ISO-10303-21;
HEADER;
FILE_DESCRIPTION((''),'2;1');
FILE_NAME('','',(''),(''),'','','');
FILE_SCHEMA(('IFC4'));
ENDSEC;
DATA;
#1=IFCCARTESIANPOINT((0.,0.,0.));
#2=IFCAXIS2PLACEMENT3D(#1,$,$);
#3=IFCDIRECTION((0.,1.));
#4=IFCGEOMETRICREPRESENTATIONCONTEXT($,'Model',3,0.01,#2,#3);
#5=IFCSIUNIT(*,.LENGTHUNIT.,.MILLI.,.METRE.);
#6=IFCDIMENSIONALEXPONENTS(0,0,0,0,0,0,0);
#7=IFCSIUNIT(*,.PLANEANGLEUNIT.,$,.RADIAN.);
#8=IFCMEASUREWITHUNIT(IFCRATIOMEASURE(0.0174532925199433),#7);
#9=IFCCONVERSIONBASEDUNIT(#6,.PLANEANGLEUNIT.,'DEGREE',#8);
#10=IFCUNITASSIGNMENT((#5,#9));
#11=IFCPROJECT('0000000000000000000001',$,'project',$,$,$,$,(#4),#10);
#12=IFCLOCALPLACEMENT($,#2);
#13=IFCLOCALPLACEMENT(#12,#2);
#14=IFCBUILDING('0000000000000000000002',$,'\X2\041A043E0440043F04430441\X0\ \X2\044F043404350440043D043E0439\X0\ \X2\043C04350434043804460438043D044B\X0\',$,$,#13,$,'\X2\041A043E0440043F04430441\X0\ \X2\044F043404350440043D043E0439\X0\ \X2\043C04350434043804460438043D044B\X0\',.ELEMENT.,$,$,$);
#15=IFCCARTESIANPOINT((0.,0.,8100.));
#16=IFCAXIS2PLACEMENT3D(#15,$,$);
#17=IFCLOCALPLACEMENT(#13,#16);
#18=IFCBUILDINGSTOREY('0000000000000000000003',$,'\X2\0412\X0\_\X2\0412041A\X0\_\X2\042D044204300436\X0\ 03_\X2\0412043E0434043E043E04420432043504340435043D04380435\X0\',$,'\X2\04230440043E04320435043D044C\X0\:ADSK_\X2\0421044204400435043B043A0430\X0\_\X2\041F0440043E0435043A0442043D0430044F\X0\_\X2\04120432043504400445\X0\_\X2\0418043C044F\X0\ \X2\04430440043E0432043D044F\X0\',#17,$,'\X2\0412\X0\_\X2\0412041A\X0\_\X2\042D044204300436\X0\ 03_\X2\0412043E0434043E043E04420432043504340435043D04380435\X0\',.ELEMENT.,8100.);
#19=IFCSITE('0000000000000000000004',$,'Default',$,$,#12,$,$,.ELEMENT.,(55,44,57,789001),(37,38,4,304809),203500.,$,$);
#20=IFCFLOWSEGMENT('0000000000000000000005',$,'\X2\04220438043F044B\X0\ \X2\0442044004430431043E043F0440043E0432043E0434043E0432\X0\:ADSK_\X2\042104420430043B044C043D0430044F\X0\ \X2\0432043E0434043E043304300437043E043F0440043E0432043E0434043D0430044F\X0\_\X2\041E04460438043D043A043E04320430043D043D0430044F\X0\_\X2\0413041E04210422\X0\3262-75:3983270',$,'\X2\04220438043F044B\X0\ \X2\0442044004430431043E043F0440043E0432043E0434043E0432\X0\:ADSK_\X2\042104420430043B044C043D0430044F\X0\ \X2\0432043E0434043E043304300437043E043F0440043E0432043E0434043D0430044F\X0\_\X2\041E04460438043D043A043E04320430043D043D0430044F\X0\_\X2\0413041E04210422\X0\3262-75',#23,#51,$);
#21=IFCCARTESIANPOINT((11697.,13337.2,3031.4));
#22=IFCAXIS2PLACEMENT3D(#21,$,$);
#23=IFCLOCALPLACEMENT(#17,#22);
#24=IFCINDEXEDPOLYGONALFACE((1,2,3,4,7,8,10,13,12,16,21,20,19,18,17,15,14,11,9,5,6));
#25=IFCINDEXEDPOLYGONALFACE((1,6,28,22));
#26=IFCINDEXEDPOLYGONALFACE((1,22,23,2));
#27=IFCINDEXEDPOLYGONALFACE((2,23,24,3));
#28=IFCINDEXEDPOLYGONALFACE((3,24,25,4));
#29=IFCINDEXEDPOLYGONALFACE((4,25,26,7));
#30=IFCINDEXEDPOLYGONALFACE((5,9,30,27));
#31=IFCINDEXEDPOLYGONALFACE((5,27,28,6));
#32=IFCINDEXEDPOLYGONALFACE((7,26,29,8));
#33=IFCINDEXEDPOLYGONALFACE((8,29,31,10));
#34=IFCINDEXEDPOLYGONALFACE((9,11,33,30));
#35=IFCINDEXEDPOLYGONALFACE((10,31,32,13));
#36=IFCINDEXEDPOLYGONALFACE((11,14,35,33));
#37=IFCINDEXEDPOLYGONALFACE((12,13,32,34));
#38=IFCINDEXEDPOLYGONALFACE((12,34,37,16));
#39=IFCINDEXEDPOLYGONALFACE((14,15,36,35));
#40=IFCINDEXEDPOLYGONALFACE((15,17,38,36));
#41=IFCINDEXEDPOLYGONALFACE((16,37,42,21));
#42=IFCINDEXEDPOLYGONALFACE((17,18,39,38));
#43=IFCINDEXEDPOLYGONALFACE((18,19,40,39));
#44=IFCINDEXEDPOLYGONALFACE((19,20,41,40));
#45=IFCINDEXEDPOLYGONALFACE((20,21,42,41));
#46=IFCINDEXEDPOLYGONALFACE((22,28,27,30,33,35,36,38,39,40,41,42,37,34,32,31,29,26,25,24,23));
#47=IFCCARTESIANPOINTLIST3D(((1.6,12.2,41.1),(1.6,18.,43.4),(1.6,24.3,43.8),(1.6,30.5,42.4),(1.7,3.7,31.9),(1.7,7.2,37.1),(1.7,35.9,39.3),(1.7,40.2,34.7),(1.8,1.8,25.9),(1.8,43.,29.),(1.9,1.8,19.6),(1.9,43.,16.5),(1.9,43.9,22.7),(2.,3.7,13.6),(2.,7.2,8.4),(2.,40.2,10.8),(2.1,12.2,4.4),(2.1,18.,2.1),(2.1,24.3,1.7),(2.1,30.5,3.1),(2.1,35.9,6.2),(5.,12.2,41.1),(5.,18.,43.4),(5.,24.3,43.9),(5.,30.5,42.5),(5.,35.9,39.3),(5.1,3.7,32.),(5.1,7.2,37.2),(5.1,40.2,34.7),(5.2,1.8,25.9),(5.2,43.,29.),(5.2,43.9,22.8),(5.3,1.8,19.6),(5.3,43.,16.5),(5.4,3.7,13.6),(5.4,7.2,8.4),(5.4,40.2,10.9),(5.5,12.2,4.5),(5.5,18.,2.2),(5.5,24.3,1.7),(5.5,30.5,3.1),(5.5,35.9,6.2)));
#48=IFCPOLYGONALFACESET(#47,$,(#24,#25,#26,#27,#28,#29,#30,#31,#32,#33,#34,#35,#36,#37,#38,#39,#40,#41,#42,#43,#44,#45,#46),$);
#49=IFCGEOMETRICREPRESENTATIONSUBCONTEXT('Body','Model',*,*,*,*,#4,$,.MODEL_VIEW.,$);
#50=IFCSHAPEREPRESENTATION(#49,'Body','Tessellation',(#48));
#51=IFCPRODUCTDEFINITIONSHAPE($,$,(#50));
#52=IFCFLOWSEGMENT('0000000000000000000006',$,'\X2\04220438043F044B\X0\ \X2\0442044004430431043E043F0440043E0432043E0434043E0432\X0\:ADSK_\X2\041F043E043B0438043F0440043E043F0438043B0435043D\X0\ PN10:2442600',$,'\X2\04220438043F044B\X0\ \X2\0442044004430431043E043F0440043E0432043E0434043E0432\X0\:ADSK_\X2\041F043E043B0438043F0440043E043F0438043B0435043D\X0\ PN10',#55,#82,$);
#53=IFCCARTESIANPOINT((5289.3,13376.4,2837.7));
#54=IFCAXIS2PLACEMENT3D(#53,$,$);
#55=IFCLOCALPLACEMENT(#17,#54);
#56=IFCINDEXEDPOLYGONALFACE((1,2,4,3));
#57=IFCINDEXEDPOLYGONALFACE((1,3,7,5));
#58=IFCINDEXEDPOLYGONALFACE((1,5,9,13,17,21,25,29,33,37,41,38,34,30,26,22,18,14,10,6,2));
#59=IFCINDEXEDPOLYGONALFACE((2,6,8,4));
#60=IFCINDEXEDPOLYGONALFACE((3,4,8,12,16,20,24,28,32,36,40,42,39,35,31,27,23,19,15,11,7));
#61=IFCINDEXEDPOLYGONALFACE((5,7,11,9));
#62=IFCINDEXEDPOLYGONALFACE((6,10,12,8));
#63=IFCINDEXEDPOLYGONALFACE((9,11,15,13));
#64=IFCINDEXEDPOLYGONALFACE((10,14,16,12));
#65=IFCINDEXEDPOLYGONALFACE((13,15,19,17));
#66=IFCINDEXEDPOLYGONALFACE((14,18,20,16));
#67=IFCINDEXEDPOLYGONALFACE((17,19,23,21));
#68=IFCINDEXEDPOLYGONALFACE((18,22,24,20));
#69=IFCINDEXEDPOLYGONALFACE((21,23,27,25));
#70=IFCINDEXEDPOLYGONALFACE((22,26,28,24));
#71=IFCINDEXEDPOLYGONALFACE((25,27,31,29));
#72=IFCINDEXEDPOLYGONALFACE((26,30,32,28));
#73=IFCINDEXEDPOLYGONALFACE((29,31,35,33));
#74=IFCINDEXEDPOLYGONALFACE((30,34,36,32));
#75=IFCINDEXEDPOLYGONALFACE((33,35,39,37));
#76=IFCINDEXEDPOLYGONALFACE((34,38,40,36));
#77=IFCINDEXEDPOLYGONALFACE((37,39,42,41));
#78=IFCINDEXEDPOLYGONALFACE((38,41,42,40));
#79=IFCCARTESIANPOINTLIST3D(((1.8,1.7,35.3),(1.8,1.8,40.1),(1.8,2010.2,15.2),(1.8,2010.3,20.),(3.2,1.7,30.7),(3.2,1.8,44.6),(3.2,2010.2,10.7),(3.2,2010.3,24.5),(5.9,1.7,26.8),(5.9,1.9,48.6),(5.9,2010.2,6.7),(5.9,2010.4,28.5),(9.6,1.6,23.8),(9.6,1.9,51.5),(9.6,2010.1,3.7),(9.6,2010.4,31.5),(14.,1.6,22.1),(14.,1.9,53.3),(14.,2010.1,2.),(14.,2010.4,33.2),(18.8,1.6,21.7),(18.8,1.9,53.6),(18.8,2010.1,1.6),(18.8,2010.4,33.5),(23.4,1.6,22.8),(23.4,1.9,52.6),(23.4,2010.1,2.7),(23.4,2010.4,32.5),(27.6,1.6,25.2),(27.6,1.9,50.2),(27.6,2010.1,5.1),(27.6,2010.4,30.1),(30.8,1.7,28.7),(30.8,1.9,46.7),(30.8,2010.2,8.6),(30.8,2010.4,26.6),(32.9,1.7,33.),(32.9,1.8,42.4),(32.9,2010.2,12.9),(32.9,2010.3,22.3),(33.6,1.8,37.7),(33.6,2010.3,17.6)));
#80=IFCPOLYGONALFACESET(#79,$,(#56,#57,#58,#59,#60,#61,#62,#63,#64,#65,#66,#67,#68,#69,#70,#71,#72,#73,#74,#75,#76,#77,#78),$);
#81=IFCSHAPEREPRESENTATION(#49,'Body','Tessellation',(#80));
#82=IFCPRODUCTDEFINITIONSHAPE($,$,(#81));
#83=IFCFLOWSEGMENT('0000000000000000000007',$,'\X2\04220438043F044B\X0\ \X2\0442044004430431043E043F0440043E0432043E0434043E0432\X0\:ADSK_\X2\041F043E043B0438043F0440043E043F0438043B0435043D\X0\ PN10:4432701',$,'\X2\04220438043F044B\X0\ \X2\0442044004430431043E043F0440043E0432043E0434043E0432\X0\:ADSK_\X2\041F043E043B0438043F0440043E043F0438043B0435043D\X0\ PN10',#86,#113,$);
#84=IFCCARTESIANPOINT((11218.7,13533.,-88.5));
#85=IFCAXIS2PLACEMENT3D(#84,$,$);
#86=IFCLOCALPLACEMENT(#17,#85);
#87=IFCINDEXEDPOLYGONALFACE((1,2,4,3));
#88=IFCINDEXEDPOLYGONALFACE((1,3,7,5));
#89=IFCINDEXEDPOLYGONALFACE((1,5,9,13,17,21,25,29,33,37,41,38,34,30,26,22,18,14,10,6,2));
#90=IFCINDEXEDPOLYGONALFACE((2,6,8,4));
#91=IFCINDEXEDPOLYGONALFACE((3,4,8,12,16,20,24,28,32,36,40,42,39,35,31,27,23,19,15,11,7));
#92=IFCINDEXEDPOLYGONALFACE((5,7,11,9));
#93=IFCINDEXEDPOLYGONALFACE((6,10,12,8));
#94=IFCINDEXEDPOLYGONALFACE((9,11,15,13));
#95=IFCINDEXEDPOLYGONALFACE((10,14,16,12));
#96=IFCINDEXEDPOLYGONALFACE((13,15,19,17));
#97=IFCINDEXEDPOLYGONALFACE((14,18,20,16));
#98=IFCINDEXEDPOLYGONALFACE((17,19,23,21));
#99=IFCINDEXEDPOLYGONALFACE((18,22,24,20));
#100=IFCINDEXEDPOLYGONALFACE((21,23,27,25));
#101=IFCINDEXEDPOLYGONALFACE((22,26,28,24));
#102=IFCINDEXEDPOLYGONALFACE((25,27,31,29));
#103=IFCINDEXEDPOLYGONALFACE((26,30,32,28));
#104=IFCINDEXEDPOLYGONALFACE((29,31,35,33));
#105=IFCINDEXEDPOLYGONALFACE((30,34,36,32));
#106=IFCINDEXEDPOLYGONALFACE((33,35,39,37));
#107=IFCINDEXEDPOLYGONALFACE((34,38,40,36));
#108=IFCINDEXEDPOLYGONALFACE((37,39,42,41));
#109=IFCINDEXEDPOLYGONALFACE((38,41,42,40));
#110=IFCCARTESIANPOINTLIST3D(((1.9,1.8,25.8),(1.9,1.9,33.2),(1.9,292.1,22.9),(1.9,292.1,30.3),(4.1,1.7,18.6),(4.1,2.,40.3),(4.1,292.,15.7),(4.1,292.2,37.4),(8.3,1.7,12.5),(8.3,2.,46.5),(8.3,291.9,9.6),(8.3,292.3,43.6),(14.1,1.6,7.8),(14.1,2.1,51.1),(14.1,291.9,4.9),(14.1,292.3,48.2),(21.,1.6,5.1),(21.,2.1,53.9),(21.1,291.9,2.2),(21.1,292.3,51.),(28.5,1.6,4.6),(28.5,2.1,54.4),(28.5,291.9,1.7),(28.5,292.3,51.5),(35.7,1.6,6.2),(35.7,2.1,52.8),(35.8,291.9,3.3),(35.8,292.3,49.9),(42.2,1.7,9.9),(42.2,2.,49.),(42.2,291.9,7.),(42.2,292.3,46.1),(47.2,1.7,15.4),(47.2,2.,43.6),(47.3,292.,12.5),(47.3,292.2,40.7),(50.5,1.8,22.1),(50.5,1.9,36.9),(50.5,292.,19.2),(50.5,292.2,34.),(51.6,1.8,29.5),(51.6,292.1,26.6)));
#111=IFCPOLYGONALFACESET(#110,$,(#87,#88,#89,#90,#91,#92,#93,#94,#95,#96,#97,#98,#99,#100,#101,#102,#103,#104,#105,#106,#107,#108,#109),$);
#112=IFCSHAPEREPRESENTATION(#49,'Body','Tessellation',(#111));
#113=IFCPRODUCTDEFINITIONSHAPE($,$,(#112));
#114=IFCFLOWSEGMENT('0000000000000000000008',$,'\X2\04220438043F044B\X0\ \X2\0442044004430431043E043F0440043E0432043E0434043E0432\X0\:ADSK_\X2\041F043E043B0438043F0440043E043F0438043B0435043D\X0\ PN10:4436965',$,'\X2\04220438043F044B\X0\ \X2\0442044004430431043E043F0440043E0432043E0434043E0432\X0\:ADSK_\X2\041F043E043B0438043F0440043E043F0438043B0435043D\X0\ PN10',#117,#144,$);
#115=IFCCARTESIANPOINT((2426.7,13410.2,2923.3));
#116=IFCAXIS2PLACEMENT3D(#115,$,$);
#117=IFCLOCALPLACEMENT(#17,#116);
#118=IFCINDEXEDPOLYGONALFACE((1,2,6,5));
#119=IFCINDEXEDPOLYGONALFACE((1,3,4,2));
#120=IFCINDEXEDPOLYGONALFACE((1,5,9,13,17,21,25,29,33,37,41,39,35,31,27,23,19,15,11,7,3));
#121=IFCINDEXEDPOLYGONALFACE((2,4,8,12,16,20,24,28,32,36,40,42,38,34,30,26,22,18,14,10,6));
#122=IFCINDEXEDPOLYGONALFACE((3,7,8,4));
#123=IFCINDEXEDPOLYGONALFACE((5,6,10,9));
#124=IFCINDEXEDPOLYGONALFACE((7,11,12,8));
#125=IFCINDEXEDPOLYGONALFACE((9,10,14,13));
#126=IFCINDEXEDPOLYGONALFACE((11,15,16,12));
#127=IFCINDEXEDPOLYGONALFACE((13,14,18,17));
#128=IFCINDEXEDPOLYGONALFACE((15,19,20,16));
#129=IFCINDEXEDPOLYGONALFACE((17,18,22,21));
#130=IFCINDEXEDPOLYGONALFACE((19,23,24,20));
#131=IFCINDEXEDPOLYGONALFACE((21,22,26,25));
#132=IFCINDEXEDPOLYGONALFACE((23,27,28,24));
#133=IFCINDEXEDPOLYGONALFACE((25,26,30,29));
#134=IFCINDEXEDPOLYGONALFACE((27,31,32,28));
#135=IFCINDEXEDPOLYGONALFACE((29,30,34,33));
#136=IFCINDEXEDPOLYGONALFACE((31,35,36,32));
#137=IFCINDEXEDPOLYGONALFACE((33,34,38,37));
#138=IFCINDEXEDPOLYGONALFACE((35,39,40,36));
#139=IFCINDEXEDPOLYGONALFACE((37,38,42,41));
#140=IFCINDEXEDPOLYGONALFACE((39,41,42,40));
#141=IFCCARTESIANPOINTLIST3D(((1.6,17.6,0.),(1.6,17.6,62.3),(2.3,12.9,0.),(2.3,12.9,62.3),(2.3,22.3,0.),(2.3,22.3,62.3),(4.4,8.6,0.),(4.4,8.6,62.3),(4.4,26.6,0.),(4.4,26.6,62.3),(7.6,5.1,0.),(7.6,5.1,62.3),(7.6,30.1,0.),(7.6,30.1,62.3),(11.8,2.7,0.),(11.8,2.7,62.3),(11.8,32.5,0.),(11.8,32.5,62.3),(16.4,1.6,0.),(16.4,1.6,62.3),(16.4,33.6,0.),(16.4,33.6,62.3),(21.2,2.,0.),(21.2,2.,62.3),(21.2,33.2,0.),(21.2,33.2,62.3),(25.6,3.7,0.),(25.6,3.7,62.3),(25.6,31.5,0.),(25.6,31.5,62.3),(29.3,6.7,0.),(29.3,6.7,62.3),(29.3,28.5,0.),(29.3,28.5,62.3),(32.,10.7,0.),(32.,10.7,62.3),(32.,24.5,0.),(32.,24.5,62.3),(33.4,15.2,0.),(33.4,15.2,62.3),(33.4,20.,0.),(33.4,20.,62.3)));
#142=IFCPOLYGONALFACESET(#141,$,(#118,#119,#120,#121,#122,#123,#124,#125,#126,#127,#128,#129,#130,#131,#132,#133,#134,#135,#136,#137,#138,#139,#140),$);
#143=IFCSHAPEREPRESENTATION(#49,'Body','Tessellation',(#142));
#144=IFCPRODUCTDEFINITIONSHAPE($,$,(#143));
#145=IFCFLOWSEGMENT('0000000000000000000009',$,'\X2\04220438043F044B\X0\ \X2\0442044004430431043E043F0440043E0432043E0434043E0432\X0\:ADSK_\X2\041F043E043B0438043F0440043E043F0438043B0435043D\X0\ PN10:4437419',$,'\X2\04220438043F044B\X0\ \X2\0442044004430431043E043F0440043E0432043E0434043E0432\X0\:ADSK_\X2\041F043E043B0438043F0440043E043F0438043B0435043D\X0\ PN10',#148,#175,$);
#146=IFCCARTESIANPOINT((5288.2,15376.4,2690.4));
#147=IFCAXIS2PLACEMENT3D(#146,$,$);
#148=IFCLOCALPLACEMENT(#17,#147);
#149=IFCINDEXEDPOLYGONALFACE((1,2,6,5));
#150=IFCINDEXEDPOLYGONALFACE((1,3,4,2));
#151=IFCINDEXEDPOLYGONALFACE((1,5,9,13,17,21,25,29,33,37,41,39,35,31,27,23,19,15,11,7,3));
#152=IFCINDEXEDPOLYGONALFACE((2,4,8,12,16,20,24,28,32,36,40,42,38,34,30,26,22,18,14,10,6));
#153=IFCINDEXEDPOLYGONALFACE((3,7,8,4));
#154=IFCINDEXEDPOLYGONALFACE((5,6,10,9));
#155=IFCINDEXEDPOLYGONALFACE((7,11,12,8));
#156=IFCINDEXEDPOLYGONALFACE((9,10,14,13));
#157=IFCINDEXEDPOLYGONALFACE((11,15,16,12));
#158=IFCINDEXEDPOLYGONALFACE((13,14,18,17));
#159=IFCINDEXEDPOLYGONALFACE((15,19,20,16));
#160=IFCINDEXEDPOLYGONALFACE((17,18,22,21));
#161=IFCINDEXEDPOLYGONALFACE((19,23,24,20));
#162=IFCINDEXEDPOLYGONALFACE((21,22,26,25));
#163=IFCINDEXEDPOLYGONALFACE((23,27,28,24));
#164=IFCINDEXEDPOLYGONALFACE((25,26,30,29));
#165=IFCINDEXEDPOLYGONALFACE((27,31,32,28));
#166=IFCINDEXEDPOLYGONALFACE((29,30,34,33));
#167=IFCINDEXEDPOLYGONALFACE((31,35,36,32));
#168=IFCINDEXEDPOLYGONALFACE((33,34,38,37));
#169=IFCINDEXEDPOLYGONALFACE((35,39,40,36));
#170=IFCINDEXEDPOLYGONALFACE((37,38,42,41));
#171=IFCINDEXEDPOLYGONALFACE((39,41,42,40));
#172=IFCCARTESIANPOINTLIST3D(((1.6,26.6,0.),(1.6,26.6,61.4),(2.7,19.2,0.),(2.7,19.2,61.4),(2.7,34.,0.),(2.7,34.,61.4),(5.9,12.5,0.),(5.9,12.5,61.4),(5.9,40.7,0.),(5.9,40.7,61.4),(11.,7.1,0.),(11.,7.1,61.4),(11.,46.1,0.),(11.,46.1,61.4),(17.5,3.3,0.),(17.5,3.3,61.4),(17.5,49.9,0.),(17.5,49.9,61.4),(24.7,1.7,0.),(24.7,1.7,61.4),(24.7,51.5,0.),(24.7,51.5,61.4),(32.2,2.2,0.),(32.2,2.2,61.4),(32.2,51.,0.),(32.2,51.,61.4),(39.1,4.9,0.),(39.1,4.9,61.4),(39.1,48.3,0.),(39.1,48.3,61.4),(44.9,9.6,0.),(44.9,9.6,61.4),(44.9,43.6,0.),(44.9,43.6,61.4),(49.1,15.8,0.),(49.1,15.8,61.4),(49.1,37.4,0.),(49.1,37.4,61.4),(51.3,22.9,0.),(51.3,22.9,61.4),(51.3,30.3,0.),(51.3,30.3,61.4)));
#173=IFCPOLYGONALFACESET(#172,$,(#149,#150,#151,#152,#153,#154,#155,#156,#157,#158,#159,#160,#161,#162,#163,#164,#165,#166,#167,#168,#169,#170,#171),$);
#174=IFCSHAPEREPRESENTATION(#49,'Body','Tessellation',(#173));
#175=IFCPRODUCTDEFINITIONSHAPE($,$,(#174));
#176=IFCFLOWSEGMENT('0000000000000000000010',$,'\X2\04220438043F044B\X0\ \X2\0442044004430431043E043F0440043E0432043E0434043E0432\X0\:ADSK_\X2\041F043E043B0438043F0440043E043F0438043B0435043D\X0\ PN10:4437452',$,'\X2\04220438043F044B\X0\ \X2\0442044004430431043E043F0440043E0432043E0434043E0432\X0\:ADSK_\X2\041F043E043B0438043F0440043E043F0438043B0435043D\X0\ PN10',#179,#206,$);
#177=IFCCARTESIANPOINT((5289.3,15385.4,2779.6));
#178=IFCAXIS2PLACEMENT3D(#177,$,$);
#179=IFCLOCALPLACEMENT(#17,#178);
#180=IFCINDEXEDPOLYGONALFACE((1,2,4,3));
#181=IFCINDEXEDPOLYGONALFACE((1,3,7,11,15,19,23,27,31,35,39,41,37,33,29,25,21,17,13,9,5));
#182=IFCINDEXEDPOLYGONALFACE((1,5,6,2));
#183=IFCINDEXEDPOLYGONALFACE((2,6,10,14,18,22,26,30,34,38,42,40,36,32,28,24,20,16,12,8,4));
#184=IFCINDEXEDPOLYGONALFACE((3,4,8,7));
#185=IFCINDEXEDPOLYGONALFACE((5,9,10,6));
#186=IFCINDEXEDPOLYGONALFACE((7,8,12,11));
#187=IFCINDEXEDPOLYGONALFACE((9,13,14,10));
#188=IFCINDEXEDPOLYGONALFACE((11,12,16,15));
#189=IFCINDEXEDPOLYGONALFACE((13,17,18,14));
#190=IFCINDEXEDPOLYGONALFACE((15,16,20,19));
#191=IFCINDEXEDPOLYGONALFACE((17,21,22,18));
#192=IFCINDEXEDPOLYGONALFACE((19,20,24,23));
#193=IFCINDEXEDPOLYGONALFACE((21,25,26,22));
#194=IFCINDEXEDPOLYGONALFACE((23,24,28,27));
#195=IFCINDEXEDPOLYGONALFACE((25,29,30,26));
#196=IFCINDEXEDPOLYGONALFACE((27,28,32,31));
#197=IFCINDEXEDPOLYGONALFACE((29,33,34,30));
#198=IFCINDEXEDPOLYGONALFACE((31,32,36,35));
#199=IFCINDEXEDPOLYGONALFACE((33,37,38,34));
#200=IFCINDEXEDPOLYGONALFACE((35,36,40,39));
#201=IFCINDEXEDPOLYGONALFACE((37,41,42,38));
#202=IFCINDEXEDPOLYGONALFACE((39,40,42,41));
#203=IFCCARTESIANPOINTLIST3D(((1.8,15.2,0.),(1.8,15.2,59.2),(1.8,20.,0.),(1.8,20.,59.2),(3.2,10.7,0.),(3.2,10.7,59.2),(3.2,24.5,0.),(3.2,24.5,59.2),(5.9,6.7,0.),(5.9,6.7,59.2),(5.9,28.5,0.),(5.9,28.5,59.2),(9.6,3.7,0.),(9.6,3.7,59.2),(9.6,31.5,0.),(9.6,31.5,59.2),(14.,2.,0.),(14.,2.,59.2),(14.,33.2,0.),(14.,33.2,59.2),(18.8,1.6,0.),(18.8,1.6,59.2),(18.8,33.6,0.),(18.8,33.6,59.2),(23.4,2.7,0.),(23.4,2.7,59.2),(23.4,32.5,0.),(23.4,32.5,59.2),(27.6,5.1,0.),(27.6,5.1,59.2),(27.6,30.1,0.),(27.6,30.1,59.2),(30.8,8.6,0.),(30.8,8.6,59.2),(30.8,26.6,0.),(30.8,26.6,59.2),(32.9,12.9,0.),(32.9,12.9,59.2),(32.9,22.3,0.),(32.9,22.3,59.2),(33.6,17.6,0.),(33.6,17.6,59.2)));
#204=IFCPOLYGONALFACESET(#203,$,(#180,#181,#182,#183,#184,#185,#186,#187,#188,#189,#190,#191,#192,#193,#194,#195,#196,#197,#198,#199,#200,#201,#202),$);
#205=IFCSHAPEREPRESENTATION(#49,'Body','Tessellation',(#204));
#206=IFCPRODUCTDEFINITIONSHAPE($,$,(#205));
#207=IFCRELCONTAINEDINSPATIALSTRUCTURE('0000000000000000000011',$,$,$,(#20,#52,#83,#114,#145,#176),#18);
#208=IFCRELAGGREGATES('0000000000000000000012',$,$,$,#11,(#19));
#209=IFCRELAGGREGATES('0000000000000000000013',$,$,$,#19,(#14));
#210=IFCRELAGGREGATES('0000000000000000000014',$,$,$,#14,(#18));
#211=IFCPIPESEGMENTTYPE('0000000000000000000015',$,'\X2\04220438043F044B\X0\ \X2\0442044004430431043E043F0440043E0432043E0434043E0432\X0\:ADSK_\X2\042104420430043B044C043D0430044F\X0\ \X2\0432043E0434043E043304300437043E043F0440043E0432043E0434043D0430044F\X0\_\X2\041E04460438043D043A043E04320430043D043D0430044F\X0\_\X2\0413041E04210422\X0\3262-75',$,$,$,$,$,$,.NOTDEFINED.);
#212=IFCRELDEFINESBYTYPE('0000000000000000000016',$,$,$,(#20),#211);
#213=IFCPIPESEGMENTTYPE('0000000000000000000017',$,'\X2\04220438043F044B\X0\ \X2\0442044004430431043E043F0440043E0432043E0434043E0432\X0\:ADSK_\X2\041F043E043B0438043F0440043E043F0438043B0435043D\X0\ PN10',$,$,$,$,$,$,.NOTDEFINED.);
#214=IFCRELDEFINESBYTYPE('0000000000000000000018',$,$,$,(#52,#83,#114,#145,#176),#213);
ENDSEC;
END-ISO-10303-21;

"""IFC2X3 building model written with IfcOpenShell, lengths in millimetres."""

from ifc_helpers import new_model, entity, si_unit, converted_unit, direction, frame, origin, origin_2d_with_axis, place, context, subcontext, project, spatial, circle, extrude, type_object, element, save


model = new_model("IFC2X3")

# Units and contexts
model_context = context("Model", 3, precision=0.01, world=origin(), true_north=direction((0.0, 1.0)))
body_context = subcontext(model_context, "Body", "Model", "MODEL_VIEW")
ifc_project = project(units=[si_unit("LENGTHUNIT", "METRE", prefix="MILLI"), converted_unit("PLANEANGLEUNIT", "DEGREE", entity("IfcRatioMeasure", 0.0174532925199433), si_unit("PLANEANGLEUNIT", "RADIAN"), dimensions=[0, 0, 0, 0, 0, 0, 0])], contexts=[model_context])

# Site, building, storey
site_placement = place(None, origin())
site = spatial("IfcSite", under=ifc_project, at=site_placement, Name="Default", CompositionType="ELEMENT", RefLatitude=(55, 44, 57, 789001), RefLongitude=(37, 38, 4, 304809), RefElevation=203500.0)
building_placement = place(site_placement, origin())
building = spatial("IfcBuilding", under=site, at=building_placement, Name="Корпус ядерной медицины", LongName="Корпус ядерной медицины", CompositionType="ELEMENT")
storey_placement = place(building_placement, frame((0.0, 0.0, 8100.0)))
storey = spatial("IfcBuildingStorey", under=building, at=storey_placement, Name="В_ВК_Этаж 03_Водоотведение", ObjectType="Уровень:ADSK_Стрелка_Проектная_Вверх_Имя уровня", LongName="В_ВК_Этаж 03_Водоотведение", CompositionType="ELEMENT", Elevation=8100.0)

# Flow segments
pipe_segment_type_1 = type_object("IfcPipeSegmentType", Name="Типы трубопроводов:ADSK_Стальная водогазопроводная_Оцинкованная_ГОСТ3262-75", PredefinedType="NOTDEFINED")
flow_segment_1_placement = place(storey_placement, frame((11697.0, 13337.2, 3031.4)))
element("IfcFlowSegment", 1, at=flow_segment_1_placement, inside=storey, type_object=pipe_segment_type_1, Name="Типы трубопроводов:ADSK_Стальная водогазопроводная_Оцинкованная_ГОСТ3262-75:3983270", ObjectType="Типы трубопроводов:ADSK_Стальная водогазопроводная_Оцинкованная_ГОСТ3262-75", context=body_context, shape_type="SweptSolid", body=[
    extrude(circle(Radius=21.1, at=origin_2d_with_axis()), frame((1.9, 22.8, 22.7), z_axis=(0.999923, 0.0, 0.012377), x_axis=(0.0, 1.0, 0.0)), (0.0, 0.0, 1.0), 3.4),
])
pipe_segment_type_2 = type_object("IfcPipeSegmentType", Name="Типы трубопроводов:ADSK_Полипропилен PN10", PredefinedType="NOTDEFINED")
flow_segment_2_placement = place(storey_placement, frame((5289.3, 13376.4, 2837.7)))
element("IfcFlowSegment", 2, at=flow_segment_2_placement, inside=storey, type_object=pipe_segment_type_2, Name="Типы трубопроводов:ADSK_Полипропилен PN10:2442600", ObjectType="Типы трубопроводов:ADSK_Полипропилен PN10", context=body_context, shape_type="SweptSolid", body=[
    extrude(circle(Radius=16.0, at=origin_2d_with_axis()), frame((17.6, 1.8, 37.7), z_axis=(0.0, 0.99995, -0.01), x_axis=(1.0, 0.0, 0.0)), (0.0, 0.0, 1.0), 2008.6),
])
flow_segment_3_placement = place(storey_placement, frame((11218.7, 13533.0, -88.5)))
element("IfcFlowSegment", 3, at=flow_segment_3_placement, inside=storey, type_object=pipe_segment_type_2, Name="Типы трубопроводов:ADSK_Полипропилен PN10:4432701", ObjectType="Типы трубопроводов:ADSK_Полипропилен PN10", context=body_context, shape_type="SweptSolid", body=[
    extrude(circle(Radius=25.0, at=origin_2d_with_axis()), frame((26.6, 292.1, 26.6), z_axis=(-0.000095, -0.99995, 0.009999), x_axis=(1.0, -0.000095, 0.0)), (0.0, 0.0, 1.0), 290.3),
])
flow_segment_4_placement = place(storey_placement, frame((2426.7, 13410.2, 2923.3)))
element("IfcFlowSegment", 4, at=flow_segment_4_placement, inside=storey, type_object=pipe_segment_type_2, Name="Типы трубопроводов:ADSK_Полипропилен PN10:4436965", ObjectType="Типы трубопроводов:ADSK_Полипропилен PN10", context=body_context, shape_type="SweptSolid", body=[
    extrude(circle(Radius=16.0, at=origin_2d_with_axis()), frame((17.6, 17.6, 0.0), z_axis=(0.0, 0.0, 1.0), x_axis=(-1.0, 0.0, 0.0)), (0.0, 0.0, 1.0), 62.3),
])
flow_segment_5_placement = place(storey_placement, frame((5288.2, 15376.4, 2690.4)))
element("IfcFlowSegment", 5, at=flow_segment_5_placement, inside=storey, type_object=pipe_segment_type_2, Name="Типы трубопроводов:ADSK_Полипропилен PN10:4437419", ObjectType="Типы трубопроводов:ADSK_Полипропилен PN10", context=body_context, shape_type="SweptSolid", body=[
    extrude(circle(Radius=25.0, at=origin_2d_with_axis()), frame((26.6, 26.6, 0.0), z_axis=(0.0, 0.0, 1.0), x_axis=(-1.0, 0.0, 0.0)), (0.0, 0.0, 1.0), 61.4),
])
flow_segment_6_placement = place(storey_placement, frame((5289.3, 15385.4, 2779.6)))
element("IfcFlowSegment", 6, at=flow_segment_6_placement, inside=storey, type_object=pipe_segment_type_2, Name="Типы трубопроводов:ADSK_Полипропилен PN10:4437452", ObjectType="Типы трубопроводов:ADSK_Полипропилен PN10", context=body_context, shape_type="SweptSolid", body=[
    extrude(circle(Radius=16.0, at=origin_2d_with_axis()), frame((17.6, 17.6, 0.0)), (0.0, 0.0, 1.0), 59.2),
])

save(model, "model.ifc")
